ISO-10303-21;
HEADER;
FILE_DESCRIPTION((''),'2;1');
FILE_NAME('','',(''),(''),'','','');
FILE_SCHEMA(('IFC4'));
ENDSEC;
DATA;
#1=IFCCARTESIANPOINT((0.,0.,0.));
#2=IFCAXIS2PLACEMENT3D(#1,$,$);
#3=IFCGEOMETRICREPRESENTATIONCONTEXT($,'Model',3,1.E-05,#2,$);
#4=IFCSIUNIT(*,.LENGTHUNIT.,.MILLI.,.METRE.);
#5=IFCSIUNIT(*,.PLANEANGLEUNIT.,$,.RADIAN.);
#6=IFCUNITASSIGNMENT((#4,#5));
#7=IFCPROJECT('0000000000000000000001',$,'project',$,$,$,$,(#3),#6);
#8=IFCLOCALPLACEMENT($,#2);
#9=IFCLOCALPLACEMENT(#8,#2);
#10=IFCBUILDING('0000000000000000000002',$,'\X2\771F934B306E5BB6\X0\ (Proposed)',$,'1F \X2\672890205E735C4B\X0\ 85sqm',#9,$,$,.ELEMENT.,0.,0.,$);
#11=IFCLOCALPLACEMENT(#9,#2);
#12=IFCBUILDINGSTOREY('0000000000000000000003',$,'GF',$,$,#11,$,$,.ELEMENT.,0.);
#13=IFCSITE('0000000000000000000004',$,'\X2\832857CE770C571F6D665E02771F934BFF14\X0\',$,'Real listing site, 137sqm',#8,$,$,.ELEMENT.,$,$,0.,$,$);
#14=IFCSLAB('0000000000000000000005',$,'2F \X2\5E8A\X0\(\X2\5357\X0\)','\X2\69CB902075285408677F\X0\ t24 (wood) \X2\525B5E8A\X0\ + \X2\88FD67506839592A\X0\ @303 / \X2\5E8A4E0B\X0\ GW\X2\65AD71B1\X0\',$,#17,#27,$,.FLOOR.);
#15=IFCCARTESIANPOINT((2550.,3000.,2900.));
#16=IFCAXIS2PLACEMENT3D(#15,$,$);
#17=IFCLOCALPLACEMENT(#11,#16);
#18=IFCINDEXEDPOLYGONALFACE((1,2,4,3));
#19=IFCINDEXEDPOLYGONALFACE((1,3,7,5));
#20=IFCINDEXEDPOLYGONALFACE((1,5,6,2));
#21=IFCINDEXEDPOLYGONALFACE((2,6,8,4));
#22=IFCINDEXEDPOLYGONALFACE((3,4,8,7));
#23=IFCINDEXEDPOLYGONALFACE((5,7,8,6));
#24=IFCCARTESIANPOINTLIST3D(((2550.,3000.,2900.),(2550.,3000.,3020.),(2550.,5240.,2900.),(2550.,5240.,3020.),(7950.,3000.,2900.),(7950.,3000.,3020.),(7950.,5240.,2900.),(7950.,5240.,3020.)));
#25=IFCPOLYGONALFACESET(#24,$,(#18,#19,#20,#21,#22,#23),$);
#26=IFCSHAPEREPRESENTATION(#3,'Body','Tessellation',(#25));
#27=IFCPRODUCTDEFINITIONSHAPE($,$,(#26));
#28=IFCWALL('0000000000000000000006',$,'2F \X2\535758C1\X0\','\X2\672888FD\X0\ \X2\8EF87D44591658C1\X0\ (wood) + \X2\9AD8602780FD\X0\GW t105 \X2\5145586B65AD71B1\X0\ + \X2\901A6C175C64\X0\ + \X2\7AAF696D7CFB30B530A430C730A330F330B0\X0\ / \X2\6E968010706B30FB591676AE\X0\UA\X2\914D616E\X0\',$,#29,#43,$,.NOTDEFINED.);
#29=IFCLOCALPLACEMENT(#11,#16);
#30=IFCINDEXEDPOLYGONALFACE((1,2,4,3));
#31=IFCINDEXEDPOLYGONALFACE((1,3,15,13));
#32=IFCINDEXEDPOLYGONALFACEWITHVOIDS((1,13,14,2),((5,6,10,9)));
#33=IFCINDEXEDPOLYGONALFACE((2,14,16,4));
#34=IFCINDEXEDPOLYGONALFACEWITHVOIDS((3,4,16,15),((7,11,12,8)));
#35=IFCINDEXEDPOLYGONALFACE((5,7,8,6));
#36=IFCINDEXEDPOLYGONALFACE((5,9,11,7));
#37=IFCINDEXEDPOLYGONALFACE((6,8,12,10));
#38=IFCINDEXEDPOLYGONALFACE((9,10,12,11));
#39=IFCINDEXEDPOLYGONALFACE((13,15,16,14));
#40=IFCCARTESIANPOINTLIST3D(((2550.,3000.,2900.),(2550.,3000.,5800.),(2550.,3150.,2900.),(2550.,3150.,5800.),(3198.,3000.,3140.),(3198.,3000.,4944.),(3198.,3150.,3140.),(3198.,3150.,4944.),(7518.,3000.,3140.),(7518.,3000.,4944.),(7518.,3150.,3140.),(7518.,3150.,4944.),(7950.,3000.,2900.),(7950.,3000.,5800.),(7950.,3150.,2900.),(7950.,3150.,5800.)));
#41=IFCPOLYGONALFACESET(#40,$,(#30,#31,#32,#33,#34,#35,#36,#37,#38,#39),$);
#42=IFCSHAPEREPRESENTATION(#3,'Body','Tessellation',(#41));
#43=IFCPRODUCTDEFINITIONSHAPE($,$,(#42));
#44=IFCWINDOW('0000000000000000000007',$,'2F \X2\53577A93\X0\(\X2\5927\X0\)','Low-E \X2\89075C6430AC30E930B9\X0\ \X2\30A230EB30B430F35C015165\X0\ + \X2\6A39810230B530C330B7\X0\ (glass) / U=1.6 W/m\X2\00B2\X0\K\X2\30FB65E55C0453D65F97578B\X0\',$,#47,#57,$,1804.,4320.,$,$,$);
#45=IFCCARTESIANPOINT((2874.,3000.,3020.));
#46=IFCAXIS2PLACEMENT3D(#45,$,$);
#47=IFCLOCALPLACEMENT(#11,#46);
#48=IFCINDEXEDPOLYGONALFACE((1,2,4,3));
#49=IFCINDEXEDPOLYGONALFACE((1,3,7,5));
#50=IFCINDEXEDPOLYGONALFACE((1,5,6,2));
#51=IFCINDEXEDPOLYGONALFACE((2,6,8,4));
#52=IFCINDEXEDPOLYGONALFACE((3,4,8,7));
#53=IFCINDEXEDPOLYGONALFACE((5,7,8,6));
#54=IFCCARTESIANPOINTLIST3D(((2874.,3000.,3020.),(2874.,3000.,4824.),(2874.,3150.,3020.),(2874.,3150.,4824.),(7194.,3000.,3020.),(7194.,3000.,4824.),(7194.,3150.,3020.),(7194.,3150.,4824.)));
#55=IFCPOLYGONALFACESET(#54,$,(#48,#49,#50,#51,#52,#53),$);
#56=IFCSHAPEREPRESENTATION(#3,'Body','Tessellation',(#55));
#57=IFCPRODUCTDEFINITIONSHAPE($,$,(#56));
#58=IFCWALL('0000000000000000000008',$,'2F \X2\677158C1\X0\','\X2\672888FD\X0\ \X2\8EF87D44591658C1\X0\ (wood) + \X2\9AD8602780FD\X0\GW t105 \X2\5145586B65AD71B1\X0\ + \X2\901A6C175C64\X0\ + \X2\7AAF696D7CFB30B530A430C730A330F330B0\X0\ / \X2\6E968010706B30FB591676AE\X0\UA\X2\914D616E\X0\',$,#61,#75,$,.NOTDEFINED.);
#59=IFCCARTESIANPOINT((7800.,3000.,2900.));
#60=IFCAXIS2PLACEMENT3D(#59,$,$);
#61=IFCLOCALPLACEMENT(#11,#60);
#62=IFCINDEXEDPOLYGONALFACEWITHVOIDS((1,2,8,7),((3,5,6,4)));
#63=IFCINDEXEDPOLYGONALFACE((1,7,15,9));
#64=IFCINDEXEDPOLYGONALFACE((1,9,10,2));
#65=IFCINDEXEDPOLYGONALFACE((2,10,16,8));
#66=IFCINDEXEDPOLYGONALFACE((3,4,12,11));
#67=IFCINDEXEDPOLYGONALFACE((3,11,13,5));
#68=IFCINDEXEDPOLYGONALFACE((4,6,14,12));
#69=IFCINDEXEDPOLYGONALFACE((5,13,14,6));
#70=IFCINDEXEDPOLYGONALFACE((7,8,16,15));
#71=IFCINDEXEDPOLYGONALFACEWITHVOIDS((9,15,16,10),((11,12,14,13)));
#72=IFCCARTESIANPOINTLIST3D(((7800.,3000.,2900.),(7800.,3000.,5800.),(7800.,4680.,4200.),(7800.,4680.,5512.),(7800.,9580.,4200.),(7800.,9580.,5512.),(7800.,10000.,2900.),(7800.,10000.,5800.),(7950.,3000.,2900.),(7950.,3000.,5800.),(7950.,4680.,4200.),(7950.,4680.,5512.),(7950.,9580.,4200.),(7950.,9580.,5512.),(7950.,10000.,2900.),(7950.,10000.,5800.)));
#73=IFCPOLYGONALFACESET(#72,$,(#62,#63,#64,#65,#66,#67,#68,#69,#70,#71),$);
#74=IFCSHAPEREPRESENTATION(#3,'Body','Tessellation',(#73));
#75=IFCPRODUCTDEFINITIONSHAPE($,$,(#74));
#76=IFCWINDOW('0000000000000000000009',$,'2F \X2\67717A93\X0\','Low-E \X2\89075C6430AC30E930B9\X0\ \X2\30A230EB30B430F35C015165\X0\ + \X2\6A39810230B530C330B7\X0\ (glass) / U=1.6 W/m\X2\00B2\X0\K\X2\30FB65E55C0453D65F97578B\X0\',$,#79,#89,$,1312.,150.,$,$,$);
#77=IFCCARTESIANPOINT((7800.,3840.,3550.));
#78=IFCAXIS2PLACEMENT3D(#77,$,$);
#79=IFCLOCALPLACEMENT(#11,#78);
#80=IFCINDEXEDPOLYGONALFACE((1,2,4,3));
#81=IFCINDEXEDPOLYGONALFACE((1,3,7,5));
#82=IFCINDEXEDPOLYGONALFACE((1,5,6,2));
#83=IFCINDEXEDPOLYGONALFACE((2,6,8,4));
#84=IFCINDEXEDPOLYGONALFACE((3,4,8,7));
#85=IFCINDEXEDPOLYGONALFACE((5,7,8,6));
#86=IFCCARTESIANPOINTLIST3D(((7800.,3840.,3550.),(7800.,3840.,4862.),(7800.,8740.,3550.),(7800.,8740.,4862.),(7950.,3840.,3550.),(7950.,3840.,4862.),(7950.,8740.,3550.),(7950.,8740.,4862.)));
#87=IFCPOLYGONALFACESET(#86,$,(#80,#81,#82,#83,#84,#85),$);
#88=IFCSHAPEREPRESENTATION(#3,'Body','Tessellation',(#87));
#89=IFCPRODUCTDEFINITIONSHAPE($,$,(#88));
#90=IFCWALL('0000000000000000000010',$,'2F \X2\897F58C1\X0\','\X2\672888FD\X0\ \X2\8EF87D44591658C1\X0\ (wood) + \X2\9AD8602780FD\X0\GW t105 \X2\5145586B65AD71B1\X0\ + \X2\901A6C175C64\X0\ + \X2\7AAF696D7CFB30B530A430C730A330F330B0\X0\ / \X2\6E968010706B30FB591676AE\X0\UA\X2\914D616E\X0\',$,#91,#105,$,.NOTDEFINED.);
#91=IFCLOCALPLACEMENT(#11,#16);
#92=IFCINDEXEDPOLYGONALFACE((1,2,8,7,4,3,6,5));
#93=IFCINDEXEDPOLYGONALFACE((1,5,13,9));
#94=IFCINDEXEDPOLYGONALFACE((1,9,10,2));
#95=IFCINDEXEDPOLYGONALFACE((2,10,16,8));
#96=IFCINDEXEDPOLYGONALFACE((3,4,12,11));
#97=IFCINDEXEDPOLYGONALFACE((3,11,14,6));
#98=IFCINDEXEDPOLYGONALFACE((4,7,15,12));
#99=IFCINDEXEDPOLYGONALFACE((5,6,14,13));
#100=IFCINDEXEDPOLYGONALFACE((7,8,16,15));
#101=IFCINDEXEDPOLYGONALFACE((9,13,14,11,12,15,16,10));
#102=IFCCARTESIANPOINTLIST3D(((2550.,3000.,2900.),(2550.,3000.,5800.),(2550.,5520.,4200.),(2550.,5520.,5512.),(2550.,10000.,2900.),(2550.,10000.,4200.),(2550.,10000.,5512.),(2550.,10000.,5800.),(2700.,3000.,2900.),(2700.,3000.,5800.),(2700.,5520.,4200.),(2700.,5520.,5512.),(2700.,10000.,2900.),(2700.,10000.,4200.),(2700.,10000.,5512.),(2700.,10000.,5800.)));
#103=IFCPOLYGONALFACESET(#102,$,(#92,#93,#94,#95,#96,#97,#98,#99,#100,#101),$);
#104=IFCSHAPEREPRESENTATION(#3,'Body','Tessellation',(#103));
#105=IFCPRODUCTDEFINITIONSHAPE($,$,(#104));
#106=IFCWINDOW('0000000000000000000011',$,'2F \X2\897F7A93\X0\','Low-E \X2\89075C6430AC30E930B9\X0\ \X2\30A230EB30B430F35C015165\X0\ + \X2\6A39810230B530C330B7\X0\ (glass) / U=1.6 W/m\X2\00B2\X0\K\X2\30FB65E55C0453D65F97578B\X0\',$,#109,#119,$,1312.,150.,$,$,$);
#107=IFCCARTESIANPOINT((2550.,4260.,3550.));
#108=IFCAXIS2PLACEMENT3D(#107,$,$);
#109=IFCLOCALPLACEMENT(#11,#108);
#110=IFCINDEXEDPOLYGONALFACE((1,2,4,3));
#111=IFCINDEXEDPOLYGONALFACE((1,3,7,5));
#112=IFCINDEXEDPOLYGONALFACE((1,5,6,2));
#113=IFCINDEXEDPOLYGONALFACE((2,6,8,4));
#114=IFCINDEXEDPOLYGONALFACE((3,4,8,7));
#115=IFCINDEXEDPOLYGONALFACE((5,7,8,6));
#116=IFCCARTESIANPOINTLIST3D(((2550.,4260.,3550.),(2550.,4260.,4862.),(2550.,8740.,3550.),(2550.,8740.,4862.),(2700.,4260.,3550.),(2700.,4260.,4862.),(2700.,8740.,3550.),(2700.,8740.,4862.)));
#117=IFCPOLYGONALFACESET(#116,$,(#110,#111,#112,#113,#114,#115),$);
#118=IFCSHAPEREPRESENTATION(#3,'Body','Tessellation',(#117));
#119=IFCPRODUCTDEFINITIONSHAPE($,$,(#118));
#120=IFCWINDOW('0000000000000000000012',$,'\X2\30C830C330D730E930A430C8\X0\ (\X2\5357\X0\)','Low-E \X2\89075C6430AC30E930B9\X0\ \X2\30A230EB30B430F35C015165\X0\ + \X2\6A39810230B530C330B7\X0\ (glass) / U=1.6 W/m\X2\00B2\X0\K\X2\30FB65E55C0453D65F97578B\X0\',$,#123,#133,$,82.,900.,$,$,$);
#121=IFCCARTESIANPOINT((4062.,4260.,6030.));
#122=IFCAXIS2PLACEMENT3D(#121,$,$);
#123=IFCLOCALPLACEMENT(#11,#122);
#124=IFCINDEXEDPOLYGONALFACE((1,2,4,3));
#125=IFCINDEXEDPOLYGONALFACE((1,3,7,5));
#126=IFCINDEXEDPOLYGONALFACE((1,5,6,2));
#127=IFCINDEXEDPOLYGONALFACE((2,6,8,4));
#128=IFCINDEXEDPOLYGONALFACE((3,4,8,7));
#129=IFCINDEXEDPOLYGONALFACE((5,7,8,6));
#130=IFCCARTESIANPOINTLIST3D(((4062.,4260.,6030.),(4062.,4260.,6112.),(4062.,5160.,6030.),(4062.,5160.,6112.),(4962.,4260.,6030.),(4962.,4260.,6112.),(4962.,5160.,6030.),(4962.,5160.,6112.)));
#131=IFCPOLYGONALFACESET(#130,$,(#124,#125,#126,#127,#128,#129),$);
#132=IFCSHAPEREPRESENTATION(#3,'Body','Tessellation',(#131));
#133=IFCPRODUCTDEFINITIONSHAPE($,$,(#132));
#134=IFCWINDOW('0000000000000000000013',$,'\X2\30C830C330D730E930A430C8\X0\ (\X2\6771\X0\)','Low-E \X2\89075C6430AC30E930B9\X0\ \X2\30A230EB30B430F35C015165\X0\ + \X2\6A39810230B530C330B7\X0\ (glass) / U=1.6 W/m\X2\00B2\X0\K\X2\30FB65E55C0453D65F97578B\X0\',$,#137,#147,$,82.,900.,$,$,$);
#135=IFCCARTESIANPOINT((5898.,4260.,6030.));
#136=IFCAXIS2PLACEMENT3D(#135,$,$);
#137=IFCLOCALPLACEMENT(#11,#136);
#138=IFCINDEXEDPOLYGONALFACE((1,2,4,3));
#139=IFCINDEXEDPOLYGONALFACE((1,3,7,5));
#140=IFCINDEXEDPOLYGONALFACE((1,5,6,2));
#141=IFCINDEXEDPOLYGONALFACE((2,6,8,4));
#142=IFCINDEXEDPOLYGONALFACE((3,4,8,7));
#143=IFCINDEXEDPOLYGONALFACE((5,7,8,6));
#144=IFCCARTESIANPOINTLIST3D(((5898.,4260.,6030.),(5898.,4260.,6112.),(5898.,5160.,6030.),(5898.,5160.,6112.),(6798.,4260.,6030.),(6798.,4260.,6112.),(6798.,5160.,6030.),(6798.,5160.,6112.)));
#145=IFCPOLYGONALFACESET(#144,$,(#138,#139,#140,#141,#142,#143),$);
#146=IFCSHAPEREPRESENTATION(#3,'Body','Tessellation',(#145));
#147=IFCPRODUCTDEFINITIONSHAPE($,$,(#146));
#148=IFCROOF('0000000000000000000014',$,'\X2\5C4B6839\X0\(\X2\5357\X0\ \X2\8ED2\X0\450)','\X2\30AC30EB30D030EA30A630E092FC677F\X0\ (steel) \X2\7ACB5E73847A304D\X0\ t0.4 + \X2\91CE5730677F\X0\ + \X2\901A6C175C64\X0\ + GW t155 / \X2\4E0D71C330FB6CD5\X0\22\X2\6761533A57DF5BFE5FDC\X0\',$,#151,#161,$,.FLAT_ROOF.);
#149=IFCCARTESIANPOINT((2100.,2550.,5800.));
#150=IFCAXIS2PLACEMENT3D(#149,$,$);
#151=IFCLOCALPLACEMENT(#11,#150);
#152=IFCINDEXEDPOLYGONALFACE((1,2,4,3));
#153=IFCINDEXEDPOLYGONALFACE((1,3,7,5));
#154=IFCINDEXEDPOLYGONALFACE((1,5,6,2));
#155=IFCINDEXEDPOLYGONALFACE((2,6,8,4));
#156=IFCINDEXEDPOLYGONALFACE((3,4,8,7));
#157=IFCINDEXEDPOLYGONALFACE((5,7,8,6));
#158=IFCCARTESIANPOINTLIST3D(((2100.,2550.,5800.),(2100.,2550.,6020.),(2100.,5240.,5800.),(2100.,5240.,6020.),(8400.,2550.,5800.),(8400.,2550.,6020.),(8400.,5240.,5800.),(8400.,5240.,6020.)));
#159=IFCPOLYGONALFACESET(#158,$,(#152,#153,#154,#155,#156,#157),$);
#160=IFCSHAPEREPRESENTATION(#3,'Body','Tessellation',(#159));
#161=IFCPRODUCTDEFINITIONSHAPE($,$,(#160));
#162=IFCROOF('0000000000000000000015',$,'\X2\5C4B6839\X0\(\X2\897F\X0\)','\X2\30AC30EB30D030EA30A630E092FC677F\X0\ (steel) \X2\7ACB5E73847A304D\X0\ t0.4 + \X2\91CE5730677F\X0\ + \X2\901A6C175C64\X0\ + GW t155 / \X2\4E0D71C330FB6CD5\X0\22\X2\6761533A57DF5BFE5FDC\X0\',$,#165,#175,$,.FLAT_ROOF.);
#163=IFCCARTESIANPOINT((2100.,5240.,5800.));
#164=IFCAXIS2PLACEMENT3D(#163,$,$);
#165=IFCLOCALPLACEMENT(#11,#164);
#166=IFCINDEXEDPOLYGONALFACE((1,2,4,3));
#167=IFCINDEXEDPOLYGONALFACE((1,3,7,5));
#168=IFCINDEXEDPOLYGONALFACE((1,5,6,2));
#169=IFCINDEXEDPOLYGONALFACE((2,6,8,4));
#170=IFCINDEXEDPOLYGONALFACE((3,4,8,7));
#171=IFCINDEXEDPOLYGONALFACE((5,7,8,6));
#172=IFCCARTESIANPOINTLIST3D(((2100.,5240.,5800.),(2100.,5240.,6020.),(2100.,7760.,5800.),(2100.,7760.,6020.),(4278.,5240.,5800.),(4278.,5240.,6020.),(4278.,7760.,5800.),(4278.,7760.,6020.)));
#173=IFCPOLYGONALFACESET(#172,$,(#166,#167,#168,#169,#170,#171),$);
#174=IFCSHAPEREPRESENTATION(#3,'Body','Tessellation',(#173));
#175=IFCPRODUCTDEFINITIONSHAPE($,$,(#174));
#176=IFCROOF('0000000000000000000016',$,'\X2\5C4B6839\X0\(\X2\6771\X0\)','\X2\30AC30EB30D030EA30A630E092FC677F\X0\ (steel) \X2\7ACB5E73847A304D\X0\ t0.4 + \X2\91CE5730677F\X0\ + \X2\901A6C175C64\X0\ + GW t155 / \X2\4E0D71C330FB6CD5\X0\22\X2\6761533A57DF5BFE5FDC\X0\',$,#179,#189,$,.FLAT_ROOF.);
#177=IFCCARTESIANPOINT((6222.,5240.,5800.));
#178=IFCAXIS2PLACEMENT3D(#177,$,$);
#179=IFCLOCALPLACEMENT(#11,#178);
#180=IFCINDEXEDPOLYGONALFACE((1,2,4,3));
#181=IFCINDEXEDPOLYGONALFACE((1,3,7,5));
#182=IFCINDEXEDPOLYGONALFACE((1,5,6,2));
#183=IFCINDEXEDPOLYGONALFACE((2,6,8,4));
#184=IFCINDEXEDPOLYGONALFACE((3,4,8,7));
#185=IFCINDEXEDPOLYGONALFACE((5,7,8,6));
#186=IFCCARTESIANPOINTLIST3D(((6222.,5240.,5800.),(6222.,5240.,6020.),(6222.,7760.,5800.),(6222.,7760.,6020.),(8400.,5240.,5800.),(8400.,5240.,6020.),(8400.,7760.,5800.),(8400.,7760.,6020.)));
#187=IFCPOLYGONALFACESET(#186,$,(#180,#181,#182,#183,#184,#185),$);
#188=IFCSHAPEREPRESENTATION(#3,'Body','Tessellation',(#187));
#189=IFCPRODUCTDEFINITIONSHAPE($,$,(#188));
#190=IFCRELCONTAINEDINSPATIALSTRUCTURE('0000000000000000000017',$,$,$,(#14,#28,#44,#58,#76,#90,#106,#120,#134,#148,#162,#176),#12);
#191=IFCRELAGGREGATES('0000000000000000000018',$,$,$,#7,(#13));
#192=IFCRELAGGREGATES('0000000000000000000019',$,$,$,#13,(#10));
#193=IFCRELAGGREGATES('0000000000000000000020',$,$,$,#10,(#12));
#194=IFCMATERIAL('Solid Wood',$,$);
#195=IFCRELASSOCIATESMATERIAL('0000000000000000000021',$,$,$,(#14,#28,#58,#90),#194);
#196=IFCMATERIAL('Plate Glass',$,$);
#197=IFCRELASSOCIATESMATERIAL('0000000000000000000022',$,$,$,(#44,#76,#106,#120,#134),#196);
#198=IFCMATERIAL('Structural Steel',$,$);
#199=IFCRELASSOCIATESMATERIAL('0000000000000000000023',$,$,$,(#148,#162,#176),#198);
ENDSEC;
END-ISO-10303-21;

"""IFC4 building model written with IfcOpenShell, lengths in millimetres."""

from ifc_helpers import new_model, si_unit, frame, frame_2d, origin, place, context, project, spatial, rectangle, extrude, material, element, fill, save


model = new_model("IFC4")

# Units and contexts
model_context = context("Model", 3, precision=1e-05, world=origin())
ifc_project = project(units=[si_unit("LENGTHUNIT", "METRE", prefix="MILLI"), si_unit("PLANEANGLEUNIT", "RADIAN")], contexts=[model_context])

# Site, building, storey
site_placement = place(None, origin())
site = spatial("IfcSite", under=ifc_project, at=site_placement, Name="茨城県土浦市真鍋４", ObjectType="Real listing site, 137sqm", CompositionType="ELEMENT", RefElevation=0.0)
building_placement = place(site_placement, origin())
building = spatial("IfcBuilding", under=site, at=building_placement, Name="真鍋の家 (Proposed)", ObjectType="1F 木造平屋 85sqm", CompositionType="ELEMENT", ElevationOfRefHeight=0.0, ElevationOfTerrain=0.0)
storey_placement = place(building_placement, origin())
storey = spatial("IfcBuildingStorey", under=building, at=storey_placement, Name="GF", CompositionType="ELEMENT", Elevation=0.0)

# Slab
ifc_material_1 = material(Name="Solid Wood")
slab_placement = place(storey_placement, frame((2550.0, 3000.0, 2900.0)))
element("IfcSlab", 1, at=slab_placement, inside=storey, material=ifc_material_1, Name="2F 床(南)", Description="構造用合板 t24 (wood) 剛床 + 製材根太 @303 / 床下 GW断熱", PredefinedType="FLOOR", context=model_context, shape_type="SweptSolid", body=[
    extrude(rectangle(XDim=5400.0, YDim=2240.0, at=frame_2d((2700.0, 1120.0))), frame((2550.0, 3000.0, 2900.0)), (0.0, 0.0, 1.0), 120.0),
])

# Walls, openings, windows
wall_1_placement = place(storey_placement, frame((2550.0, 3000.0, 2900.0)))
wall_1 = element("IfcWall", 2, at=wall_1_placement, inside=storey, material=ifc_material_1, Name="2F 南壁", Description="木製 軸組外壁 (wood) + 高性能GW t105 充填断熱 + 通気層 + 窯業系サイディング / 準耐火・外皮UA配慮", PredefinedType="NOTDEFINED", context=model_context, shape_type="SweptSolid", body=[
    extrude(rectangle(XDim=5400.0, YDim=150.0, at=frame_2d((2700.0, 75.0))), frame((2550.0, 3000.0, 2900.0)), (0.0, 0.0, 1.0), 2900.0),
])
opening_1_placement = place(storey_placement, frame((2874.0, 3000.0, 3020.0)))
opening_1 = element("IfcOpeningElement", 3, at=opening_1_placement, cuts=wall_1, PredefinedType="NOTDEFINED", context=model_context, shape_type="SweptSolid", body=[
    extrude(rectangle(XDim=4320.0, YDim=150.0, at=frame_2d((2160.0, 75.0))), frame((2874.0, 3000.0, 3020.0)), (0.0, 0.0, 1.0), 1804.0),
])
ifc_material_2 = material(Name="Plate Glass")
window_1_placement = place(storey_placement, frame((2874.0, 3000.0, 3020.0)))
window_1 = element("IfcWindow", 4, at=window_1_placement, inside=storey, material=ifc_material_2, Name="2F 南窓(大)", Description="Low-E 複層ガラス アルゴン封入 + 樹脂サッシ (glass) / U=1.6 W/m²K・日射取得型", OverallHeight=1804.0, OverallWidth=4320.0, context=model_context, shape_type="SweptSolid", body=[
    extrude(rectangle(XDim=4320.0, YDim=150.0, at=frame_2d((2160.0, 75.0))), frame((2874.0, 3000.0, 3020.0)), (0.0, 0.0, 1.0), 1804.0),
])
fill(opening_1, window_1)
wall_2_placement = place(storey_placement, frame((7800.0, 3000.0, 2900.0)))
wall_2 = element("IfcWall", 5, at=wall_2_placement, inside=storey, material=ifc_material_1, Name="2F 東壁", Description="木製 軸組外壁 (wood) + 高性能GW t105 充填断熱 + 通気層 + 窯業系サイディング / 準耐火・外皮UA配慮", PredefinedType="NOTDEFINED", context=model_context, shape_type="SweptSolid", body=[
    extrude(rectangle(XDim=150.0, YDim=7000.0, at=frame_2d((75.0, 3500.0))), frame((7800.0, 3000.0, 2900.0)), (0.0, 0.0, 1.0), 2900.0),
])
opening_2_placement = place(storey_placement, frame((7800.0, 3840.0, 3550.0)))
opening_2 = element("IfcOpeningElement", 6, at=opening_2_placement, cuts=wall_2, PredefinedType="NOTDEFINED", context=model_context, shape_type="SweptSolid", body=[
    extrude(rectangle(XDim=150.0, YDim=4900.0, at=frame_2d((75.0, 2450.0))), frame((7800.0, 3840.0, 3550.0)), (0.0, 0.0, 1.0), 1312.0),
])
window_2_placement = place(storey_placement, frame((7800.0, 3840.0, 3550.0)))
window_2 = element("IfcWindow", 7, at=window_2_placement, inside=storey, material=ifc_material_2, Name="2F 東窓", Description="Low-E 複層ガラス アルゴン封入 + 樹脂サッシ (glass) / U=1.6 W/m²K・日射取得型", OverallHeight=1312.0, OverallWidth=150.0, context=model_context, shape_type="SweptSolid", body=[
    extrude(rectangle(XDim=150.0, YDim=4900.0, at=frame_2d((75.0, 2450.0))), frame((7800.0, 3840.0, 3550.0)), (0.0, 0.0, 1.0), 1312.0),
])
fill(opening_2, window_2)
wall_3_placement = place(storey_placement, frame((2550.0, 3000.0, 2900.0)))
wall_3 = element("IfcWall", 8, at=wall_3_placement, inside=storey, material=ifc_material_1, Name="2F 西壁", Description="木製 軸組外壁 (wood) + 高性能GW t105 充填断熱 + 通気層 + 窯業系サイディング / 準耐火・外皮UA配慮", PredefinedType="NOTDEFINED", context=model_context, shape_type="SweptSolid", body=[
    extrude(rectangle(XDim=150.0, YDim=7000.0, at=frame_2d((75.0, 3500.0))), frame((2550.0, 3000.0, 2900.0)), (0.0, 0.0, 1.0), 2900.0),
])
opening_3_placement = place(storey_placement, frame((2550.0, 4260.0, 3550.0)))
opening_3 = element("IfcOpeningElement", 9, at=opening_3_placement, cuts=wall_3, PredefinedType="NOTDEFINED", context=model_context, shape_type="SweptSolid", body=[
    extrude(rectangle(XDim=150.0, YDim=4480.0, at=frame_2d((75.0, 2240.0))), frame((2550.0, 4260.0, 3550.0)), (0.0, 0.0, 1.0), 1312.0),
])
window_3_placement = place(storey_placement, frame((2550.0, 4260.0, 3550.0)))
window_3 = element("IfcWindow", 10, at=window_3_placement, inside=storey, material=ifc_material_2, Name="2F 西窓", Description="Low-E 複層ガラス アルゴン封入 + 樹脂サッシ (glass) / U=1.6 W/m²K・日射取得型", OverallHeight=1312.0, OverallWidth=150.0, context=model_context, shape_type="SweptSolid", body=[
    extrude(rectangle(XDim=150.0, YDim=4480.0, at=frame_2d((75.0, 2240.0))), frame((2550.0, 4260.0, 3550.0)), (0.0, 0.0, 1.0), 1312.0),
])
fill(opening_3, window_3)

# Windows
window_4_placement = place(storey_placement, frame((4062.0, 4260.0, 6030.0)))
element("IfcWindow", 11, at=window_4_placement, inside=storey, material=ifc_material_2, Name="トップライト (南)", Description="Low-E 複層ガラス アルゴン封入 + 樹脂サッシ (glass) / U=1.6 W/m²K・日射取得型", OverallHeight=82.0, OverallWidth=900.0, context=model_context, shape_type="SweptSolid", body=[
    extrude(rectangle(XDim=900.0, YDim=900.0, at=frame_2d((450.0, 450.0))), frame((4062.0, 4260.0, 6030.0)), (0.0, 0.0, 1.0), 82.0),
])
window_5_placement = place(storey_placement, frame((5898.0, 4260.0, 6030.0)))
element("IfcWindow", 12, at=window_5_placement, inside=storey, material=ifc_material_2, Name="トップライト (東)", Description="Low-E 複層ガラス アルゴン封入 + 樹脂サッシ (glass) / U=1.6 W/m²K・日射取得型", OverallHeight=82.0, OverallWidth=900.0, context=model_context, shape_type="SweptSolid", body=[
    extrude(rectangle(XDim=900.0, YDim=900.0, at=frame_2d((450.0, 450.0))), frame((5898.0, 4260.0, 6030.0)), (0.0, 0.0, 1.0), 82.0),
])

# Roofs
ifc_material_3 = material(Name="Structural Steel")
roof_1_placement = place(storey_placement, frame((2100.0, 2550.0, 5800.0)))
element("IfcRoof", 13, at=roof_1_placement, inside=storey, material=ifc_material_3, Name="屋根(南 軒450)", Description="ガルバリウム鋼板 (steel) 立平葺き t0.4 + 野地板 + 通気層 + GW t155 / 不燃・法22条区域対応", PredefinedType="FLAT_ROOF", context=model_context, shape_type="SweptSolid", body=[
    extrude(rectangle(XDim=6300.0, YDim=2690.0, at=frame_2d((3150.0, 1345.0))), frame((2100.0, 2550.0, 5800.0)), (0.0, 0.0, 1.0), 220.0),
])
roof_2_placement = place(storey_placement, frame((2100.0, 5240.0, 5800.0)))
element("IfcRoof", 14, at=roof_2_placement, inside=storey, material=ifc_material_3, Name="屋根(西)", Description="ガルバリウム鋼板 (steel) 立平葺き t0.4 + 野地板 + 通気層 + GW t155 / 不燃・法22条区域対応", PredefinedType="FLAT_ROOF", context=model_context, shape_type="SweptSolid", body=[
    extrude(rectangle(XDim=2178.0, YDim=2520.0, at=frame_2d((1089.0, 1260.0))), frame((2100.0, 5240.0, 5800.0)), (0.0, 0.0, 1.0), 220.0),
])
roof_3_placement = place(storey_placement, frame((6222.0, 5240.0, 5800.0)))
element("IfcRoof", 15, at=roof_3_placement, inside=storey, material=ifc_material_3, Name="屋根(東)", Description="ガルバリウム鋼板 (steel) 立平葺き t0.4 + 野地板 + 通気層 + GW t155 / 不燃・法22条区域対応", PredefinedType="FLAT_ROOF", context=model_context, shape_type="SweptSolid", body=[
    extrude(rectangle(XDim=2178.0, YDim=2520.0, at=frame_2d((1089.0, 1260.0))), frame((6222.0, 5240.0, 5800.0)), (0.0, 0.0, 1.0), 220.0),
])

save(model, "model.ifc")
